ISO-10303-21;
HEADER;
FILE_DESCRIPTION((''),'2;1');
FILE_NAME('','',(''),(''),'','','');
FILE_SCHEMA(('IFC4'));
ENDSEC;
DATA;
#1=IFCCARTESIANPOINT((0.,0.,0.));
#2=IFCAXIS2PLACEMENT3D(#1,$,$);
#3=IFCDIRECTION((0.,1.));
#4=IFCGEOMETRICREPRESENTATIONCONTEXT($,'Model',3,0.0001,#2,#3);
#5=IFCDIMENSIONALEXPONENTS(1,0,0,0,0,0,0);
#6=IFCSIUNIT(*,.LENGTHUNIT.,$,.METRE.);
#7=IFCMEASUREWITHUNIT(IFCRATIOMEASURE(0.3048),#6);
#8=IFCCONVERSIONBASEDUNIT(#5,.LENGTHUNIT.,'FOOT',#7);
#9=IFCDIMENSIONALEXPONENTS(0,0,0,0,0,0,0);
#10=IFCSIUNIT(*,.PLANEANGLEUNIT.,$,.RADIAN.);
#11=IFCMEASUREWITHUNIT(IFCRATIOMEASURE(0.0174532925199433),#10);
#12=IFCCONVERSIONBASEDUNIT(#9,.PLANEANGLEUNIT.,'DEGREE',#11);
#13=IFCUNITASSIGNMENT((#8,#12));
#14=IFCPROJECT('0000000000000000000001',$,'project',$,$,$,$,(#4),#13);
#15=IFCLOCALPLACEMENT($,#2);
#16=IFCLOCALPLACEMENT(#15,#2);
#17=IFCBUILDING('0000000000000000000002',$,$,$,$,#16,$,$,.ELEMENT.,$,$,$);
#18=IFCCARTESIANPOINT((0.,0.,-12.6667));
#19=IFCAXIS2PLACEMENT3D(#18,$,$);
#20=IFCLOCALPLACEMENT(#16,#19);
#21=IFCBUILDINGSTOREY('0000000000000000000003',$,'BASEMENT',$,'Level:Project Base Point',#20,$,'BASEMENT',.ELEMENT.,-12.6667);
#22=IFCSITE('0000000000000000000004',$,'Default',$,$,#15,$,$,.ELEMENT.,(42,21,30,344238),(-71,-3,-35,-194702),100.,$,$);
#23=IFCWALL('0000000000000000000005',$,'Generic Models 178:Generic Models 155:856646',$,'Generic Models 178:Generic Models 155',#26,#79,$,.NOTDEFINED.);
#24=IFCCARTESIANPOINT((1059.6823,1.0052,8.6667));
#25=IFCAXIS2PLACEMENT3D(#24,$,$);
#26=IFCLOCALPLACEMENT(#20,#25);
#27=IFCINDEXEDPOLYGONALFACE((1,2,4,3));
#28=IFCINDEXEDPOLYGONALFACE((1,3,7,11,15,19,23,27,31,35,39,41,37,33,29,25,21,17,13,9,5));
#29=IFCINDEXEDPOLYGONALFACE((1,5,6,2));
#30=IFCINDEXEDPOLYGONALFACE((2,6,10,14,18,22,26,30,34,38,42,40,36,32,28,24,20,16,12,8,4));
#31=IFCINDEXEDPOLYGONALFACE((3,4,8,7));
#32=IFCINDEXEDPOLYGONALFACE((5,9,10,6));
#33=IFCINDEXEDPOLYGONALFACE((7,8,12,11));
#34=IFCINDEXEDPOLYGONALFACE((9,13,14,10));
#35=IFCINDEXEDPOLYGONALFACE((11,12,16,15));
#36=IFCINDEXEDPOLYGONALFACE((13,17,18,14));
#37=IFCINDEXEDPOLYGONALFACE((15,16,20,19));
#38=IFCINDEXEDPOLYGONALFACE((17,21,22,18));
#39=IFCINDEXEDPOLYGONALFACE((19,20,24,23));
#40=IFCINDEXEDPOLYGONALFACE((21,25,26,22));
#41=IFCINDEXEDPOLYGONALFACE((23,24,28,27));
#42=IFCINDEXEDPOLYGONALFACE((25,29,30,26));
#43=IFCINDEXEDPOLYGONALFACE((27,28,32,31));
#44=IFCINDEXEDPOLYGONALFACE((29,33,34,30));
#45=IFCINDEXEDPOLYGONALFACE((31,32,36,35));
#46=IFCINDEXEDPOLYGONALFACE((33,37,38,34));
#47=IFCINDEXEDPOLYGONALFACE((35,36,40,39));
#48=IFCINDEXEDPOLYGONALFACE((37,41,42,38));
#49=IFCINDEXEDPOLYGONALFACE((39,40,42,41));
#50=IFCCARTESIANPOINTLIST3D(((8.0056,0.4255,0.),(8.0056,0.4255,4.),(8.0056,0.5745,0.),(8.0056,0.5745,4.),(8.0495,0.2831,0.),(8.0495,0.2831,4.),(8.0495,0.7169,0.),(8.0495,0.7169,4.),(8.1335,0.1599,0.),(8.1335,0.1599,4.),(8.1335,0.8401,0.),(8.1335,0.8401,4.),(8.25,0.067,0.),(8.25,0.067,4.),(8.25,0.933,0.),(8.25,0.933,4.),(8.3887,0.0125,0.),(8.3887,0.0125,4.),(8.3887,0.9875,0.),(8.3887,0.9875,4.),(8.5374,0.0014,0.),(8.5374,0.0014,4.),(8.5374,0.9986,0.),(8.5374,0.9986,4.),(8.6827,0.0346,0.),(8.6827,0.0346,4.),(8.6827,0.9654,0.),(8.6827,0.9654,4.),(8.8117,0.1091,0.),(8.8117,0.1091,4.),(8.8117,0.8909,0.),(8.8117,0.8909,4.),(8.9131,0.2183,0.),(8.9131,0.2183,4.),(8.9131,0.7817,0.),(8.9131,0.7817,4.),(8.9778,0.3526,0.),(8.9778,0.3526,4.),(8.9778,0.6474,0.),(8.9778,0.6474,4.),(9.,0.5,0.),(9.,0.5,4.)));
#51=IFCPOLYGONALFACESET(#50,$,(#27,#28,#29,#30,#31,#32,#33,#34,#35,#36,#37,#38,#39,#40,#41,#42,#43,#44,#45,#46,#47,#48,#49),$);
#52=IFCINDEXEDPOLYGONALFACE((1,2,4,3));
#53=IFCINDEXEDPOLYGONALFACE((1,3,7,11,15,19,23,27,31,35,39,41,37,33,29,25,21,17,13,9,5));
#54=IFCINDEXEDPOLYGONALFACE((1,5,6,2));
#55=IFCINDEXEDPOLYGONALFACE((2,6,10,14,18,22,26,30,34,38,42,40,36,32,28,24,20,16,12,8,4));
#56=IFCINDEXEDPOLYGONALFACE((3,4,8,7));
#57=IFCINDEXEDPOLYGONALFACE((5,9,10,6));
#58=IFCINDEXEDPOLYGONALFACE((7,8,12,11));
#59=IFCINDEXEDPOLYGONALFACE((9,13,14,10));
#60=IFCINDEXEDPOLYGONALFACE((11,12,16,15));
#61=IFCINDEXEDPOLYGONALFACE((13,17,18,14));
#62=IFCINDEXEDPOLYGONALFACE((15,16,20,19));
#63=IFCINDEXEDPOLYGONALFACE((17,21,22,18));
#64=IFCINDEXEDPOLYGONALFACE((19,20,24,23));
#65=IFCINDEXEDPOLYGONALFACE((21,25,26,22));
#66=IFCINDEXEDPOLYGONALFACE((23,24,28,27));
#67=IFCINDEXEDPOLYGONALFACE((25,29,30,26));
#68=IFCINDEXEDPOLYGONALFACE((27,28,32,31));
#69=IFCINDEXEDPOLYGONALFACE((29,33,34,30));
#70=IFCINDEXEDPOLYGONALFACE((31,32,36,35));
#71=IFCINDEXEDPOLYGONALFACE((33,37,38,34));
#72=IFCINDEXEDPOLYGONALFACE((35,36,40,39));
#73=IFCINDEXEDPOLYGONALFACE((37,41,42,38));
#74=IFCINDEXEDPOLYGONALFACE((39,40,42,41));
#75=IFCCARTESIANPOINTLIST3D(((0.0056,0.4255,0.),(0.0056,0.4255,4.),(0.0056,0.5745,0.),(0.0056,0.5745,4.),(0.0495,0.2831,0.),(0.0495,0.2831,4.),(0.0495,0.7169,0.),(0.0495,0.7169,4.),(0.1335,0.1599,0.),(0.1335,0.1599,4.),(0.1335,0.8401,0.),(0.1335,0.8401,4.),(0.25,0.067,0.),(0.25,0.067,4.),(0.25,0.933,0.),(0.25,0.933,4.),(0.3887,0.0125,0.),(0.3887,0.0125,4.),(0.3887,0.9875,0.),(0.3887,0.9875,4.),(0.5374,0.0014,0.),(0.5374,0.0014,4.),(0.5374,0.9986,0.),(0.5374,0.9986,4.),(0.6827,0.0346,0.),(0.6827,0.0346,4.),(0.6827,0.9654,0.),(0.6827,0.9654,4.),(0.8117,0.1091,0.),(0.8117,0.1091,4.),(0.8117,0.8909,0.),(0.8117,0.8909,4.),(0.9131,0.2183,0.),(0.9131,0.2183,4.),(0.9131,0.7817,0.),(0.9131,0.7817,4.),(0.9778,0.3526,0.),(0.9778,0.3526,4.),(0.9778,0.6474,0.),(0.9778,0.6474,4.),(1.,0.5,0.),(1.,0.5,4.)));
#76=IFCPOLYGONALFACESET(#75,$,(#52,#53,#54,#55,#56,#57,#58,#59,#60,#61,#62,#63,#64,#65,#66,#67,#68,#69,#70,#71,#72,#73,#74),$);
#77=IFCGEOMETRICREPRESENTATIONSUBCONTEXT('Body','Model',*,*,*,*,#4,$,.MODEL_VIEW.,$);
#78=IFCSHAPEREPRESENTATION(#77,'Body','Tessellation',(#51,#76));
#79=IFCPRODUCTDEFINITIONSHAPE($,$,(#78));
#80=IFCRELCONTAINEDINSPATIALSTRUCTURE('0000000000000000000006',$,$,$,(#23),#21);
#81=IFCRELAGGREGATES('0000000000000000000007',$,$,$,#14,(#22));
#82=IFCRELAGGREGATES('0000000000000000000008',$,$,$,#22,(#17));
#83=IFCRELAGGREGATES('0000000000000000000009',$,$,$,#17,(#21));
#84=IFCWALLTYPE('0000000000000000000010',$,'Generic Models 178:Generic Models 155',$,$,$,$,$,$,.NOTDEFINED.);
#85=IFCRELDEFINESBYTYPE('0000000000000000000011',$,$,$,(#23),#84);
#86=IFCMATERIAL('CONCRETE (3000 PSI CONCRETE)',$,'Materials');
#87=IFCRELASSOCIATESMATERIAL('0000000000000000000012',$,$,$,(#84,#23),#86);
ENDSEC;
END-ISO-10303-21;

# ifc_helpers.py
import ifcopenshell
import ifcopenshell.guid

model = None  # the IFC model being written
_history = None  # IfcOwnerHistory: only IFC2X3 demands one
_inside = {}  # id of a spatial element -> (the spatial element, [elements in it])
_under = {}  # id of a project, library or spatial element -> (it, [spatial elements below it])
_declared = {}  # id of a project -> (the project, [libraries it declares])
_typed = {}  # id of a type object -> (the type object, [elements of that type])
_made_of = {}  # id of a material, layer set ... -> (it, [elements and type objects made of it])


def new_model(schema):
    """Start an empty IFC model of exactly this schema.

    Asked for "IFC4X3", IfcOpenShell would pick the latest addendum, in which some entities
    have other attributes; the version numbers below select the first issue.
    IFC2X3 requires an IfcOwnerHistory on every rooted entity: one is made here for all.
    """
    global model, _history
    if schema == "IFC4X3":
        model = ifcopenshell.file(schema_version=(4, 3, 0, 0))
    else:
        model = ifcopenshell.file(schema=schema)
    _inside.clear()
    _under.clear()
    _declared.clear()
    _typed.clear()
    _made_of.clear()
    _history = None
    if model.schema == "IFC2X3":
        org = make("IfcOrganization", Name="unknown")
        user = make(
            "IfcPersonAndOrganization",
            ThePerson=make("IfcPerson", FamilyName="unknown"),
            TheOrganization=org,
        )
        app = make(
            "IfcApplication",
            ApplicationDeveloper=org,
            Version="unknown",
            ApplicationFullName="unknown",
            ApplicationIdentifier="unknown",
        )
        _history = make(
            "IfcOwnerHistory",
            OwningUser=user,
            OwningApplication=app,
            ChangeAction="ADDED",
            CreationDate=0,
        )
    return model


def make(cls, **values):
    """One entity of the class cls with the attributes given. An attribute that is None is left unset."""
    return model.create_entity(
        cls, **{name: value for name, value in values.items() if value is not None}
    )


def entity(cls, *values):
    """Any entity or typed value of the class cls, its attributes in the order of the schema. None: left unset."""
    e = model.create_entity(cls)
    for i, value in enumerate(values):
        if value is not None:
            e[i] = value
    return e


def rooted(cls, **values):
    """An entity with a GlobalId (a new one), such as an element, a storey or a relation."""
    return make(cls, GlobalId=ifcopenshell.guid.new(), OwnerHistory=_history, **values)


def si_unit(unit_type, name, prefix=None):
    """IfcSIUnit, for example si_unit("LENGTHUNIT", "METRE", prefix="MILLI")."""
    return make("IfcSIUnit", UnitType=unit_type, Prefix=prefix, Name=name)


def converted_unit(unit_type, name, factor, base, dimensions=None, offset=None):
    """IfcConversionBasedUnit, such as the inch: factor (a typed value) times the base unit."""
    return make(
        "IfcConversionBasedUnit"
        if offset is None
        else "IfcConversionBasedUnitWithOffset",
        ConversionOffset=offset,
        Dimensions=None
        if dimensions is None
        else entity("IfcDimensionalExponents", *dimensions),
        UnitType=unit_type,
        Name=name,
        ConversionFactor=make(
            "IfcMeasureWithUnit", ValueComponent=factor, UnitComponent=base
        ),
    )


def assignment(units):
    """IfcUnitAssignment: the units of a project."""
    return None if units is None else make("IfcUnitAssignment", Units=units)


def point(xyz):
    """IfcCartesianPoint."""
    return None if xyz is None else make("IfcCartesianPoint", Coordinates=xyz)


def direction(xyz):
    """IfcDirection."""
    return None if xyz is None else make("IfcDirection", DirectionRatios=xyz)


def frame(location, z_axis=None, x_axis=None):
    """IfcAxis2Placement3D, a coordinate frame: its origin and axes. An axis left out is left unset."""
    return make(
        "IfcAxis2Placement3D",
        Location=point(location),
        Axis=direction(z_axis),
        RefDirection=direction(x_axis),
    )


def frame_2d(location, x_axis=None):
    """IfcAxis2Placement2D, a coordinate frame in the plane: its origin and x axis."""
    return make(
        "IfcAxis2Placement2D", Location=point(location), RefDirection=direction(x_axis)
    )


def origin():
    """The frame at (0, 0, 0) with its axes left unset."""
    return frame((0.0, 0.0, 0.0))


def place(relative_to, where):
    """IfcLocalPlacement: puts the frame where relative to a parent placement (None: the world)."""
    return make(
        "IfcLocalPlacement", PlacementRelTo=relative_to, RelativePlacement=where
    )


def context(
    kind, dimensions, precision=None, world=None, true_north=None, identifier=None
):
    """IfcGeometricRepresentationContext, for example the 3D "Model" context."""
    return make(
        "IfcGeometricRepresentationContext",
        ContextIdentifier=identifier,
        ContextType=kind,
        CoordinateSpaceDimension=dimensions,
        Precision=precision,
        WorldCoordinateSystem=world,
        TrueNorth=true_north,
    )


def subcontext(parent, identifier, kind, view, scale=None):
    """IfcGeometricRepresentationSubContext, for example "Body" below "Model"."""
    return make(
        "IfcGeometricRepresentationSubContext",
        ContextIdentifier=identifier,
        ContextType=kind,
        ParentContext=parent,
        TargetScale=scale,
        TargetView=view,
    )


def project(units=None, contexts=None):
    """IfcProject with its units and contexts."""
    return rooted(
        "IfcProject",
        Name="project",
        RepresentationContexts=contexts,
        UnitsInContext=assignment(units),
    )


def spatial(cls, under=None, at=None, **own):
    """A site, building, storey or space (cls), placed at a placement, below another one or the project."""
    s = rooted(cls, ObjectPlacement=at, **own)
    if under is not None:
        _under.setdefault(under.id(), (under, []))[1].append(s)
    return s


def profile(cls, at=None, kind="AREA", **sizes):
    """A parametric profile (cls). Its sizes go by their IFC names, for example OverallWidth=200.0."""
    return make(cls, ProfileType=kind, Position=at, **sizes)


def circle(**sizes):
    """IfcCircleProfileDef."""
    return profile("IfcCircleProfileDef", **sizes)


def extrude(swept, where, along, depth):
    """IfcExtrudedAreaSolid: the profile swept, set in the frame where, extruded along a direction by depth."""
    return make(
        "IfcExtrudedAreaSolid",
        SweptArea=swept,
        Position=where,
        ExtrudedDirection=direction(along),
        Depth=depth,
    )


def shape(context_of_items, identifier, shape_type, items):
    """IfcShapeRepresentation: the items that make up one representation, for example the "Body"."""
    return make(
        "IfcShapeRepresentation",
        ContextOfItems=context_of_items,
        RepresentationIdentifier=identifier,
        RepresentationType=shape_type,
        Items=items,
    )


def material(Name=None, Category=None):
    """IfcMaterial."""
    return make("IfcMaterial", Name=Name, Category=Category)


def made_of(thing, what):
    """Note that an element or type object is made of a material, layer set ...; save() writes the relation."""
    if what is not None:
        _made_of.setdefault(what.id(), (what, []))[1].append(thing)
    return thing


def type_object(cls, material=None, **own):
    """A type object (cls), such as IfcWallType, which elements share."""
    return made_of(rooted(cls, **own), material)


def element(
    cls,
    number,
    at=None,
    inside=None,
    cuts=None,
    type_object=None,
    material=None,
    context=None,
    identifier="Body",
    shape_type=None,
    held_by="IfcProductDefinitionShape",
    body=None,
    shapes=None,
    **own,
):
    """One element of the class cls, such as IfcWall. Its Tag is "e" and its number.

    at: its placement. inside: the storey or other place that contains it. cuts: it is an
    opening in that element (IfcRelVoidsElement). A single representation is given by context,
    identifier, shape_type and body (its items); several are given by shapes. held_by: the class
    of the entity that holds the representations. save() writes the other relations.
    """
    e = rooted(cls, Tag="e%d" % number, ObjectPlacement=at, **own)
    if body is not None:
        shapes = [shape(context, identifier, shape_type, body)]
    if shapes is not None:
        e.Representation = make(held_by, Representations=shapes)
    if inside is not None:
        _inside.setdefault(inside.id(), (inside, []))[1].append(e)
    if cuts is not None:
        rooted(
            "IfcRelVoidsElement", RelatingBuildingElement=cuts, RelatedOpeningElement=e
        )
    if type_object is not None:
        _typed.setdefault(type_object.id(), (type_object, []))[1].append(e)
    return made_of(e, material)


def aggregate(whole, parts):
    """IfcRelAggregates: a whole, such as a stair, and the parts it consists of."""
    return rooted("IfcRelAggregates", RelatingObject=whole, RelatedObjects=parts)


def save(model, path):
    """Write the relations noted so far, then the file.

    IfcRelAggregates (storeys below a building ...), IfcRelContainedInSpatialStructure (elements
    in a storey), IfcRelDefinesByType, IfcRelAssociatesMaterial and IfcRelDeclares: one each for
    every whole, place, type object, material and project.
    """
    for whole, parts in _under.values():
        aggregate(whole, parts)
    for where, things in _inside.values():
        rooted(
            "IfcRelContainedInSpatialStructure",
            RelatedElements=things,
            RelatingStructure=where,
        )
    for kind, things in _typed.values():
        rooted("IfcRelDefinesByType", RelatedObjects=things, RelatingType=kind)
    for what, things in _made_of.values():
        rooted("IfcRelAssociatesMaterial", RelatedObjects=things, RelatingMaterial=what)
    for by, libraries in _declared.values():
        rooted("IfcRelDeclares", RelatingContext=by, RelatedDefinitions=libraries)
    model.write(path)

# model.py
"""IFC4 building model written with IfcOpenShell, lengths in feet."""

from ifc_helpers import new_model, entity, si_unit, converted_unit, direction, frame, frame_2d, origin, place, context, subcontext, project, spatial, circle, extrude, material, type_object, element, save


model = new_model("IFC4")

# Units and contexts
model_context = context("Model", 3, precision=0.0001, world=origin(), true_north=direction((0.0, 1.0)))
body_context = subcontext(model_context, "Body", "Model", "MODEL_VIEW")
ifc_project = project(units=[converted_unit("LENGTHUNIT", "FOOT", entity("IfcRatioMeasure", 0.3048), si_unit("LENGTHUNIT", "METRE"), dimensions=[1, 0, 0, 0, 0, 0, 0]), converted_unit("PLANEANGLEUNIT", "DEGREE", entity("IfcRatioMeasure", 0.0174532925199433), si_unit("PLANEANGLEUNIT", "RADIAN"), dimensions=[0, 0, 0, 0, 0, 0, 0])], contexts=[model_context])

# Site, building, storey
site_placement = place(None, origin())
site = spatial("IfcSite", under=ifc_project, at=site_placement, Name="Default", CompositionType="ELEMENT", RefLatitude=(42, 21, 30, 344238), RefLongitude=(-71, -3, -35, -194702), RefElevation=100.0)
building_placement = place(site_placement, origin())
building = spatial("IfcBuilding", under=site, at=building_placement, CompositionType="ELEMENT")
storey_placement = place(building_placement, frame((0.0, 0.0, -12.6667)))
storey = spatial("IfcBuildingStorey", under=building, at=storey_placement, Name="BASEMENT", ObjectType="Level:Project Base Point", LongName="BASEMENT", CompositionType="ELEMENT", Elevation=-12.6667)

# Wall
ifc_material_1 = material(Name="CONCRETE (3000 PSI CONCRETE)", Category="Materials")
wall_type_1 = type_object("IfcWallType", Name="Generic Models 178:Generic Models 155", PredefinedType="NOTDEFINED", material=ifc_material_1)
wall_1_placement = place(storey_placement, frame((1059.6823, 1.0052, 8.6667)))
element("IfcWall", 1, at=wall_1_placement, inside=storey, type_object=wall_type_1, material=ifc_material_1, Name="Generic Models 178:Generic Models 155:856646", ObjectType="Generic Models 178:Generic Models 155", PredefinedType="NOTDEFINED", context=body_context, shape_type="SweptSolid", body=[
    extrude(circle(Radius=0.5, at=frame_2d((0.0, 0.0), x_axis=(1.0, 0.0))), frame((8.5, 0.5, 0.0)), (0.0, 0.0, 1.0), 4.0),
    extrude(circle(Radius=0.5, at=frame_2d((0.0, 0.0), x_axis=(1.0, 0.0))), frame((0.5, 0.5, 0.0)), (0.0, 0.0, 1.0), 4.0),
])

save(model, "model.ifc")
